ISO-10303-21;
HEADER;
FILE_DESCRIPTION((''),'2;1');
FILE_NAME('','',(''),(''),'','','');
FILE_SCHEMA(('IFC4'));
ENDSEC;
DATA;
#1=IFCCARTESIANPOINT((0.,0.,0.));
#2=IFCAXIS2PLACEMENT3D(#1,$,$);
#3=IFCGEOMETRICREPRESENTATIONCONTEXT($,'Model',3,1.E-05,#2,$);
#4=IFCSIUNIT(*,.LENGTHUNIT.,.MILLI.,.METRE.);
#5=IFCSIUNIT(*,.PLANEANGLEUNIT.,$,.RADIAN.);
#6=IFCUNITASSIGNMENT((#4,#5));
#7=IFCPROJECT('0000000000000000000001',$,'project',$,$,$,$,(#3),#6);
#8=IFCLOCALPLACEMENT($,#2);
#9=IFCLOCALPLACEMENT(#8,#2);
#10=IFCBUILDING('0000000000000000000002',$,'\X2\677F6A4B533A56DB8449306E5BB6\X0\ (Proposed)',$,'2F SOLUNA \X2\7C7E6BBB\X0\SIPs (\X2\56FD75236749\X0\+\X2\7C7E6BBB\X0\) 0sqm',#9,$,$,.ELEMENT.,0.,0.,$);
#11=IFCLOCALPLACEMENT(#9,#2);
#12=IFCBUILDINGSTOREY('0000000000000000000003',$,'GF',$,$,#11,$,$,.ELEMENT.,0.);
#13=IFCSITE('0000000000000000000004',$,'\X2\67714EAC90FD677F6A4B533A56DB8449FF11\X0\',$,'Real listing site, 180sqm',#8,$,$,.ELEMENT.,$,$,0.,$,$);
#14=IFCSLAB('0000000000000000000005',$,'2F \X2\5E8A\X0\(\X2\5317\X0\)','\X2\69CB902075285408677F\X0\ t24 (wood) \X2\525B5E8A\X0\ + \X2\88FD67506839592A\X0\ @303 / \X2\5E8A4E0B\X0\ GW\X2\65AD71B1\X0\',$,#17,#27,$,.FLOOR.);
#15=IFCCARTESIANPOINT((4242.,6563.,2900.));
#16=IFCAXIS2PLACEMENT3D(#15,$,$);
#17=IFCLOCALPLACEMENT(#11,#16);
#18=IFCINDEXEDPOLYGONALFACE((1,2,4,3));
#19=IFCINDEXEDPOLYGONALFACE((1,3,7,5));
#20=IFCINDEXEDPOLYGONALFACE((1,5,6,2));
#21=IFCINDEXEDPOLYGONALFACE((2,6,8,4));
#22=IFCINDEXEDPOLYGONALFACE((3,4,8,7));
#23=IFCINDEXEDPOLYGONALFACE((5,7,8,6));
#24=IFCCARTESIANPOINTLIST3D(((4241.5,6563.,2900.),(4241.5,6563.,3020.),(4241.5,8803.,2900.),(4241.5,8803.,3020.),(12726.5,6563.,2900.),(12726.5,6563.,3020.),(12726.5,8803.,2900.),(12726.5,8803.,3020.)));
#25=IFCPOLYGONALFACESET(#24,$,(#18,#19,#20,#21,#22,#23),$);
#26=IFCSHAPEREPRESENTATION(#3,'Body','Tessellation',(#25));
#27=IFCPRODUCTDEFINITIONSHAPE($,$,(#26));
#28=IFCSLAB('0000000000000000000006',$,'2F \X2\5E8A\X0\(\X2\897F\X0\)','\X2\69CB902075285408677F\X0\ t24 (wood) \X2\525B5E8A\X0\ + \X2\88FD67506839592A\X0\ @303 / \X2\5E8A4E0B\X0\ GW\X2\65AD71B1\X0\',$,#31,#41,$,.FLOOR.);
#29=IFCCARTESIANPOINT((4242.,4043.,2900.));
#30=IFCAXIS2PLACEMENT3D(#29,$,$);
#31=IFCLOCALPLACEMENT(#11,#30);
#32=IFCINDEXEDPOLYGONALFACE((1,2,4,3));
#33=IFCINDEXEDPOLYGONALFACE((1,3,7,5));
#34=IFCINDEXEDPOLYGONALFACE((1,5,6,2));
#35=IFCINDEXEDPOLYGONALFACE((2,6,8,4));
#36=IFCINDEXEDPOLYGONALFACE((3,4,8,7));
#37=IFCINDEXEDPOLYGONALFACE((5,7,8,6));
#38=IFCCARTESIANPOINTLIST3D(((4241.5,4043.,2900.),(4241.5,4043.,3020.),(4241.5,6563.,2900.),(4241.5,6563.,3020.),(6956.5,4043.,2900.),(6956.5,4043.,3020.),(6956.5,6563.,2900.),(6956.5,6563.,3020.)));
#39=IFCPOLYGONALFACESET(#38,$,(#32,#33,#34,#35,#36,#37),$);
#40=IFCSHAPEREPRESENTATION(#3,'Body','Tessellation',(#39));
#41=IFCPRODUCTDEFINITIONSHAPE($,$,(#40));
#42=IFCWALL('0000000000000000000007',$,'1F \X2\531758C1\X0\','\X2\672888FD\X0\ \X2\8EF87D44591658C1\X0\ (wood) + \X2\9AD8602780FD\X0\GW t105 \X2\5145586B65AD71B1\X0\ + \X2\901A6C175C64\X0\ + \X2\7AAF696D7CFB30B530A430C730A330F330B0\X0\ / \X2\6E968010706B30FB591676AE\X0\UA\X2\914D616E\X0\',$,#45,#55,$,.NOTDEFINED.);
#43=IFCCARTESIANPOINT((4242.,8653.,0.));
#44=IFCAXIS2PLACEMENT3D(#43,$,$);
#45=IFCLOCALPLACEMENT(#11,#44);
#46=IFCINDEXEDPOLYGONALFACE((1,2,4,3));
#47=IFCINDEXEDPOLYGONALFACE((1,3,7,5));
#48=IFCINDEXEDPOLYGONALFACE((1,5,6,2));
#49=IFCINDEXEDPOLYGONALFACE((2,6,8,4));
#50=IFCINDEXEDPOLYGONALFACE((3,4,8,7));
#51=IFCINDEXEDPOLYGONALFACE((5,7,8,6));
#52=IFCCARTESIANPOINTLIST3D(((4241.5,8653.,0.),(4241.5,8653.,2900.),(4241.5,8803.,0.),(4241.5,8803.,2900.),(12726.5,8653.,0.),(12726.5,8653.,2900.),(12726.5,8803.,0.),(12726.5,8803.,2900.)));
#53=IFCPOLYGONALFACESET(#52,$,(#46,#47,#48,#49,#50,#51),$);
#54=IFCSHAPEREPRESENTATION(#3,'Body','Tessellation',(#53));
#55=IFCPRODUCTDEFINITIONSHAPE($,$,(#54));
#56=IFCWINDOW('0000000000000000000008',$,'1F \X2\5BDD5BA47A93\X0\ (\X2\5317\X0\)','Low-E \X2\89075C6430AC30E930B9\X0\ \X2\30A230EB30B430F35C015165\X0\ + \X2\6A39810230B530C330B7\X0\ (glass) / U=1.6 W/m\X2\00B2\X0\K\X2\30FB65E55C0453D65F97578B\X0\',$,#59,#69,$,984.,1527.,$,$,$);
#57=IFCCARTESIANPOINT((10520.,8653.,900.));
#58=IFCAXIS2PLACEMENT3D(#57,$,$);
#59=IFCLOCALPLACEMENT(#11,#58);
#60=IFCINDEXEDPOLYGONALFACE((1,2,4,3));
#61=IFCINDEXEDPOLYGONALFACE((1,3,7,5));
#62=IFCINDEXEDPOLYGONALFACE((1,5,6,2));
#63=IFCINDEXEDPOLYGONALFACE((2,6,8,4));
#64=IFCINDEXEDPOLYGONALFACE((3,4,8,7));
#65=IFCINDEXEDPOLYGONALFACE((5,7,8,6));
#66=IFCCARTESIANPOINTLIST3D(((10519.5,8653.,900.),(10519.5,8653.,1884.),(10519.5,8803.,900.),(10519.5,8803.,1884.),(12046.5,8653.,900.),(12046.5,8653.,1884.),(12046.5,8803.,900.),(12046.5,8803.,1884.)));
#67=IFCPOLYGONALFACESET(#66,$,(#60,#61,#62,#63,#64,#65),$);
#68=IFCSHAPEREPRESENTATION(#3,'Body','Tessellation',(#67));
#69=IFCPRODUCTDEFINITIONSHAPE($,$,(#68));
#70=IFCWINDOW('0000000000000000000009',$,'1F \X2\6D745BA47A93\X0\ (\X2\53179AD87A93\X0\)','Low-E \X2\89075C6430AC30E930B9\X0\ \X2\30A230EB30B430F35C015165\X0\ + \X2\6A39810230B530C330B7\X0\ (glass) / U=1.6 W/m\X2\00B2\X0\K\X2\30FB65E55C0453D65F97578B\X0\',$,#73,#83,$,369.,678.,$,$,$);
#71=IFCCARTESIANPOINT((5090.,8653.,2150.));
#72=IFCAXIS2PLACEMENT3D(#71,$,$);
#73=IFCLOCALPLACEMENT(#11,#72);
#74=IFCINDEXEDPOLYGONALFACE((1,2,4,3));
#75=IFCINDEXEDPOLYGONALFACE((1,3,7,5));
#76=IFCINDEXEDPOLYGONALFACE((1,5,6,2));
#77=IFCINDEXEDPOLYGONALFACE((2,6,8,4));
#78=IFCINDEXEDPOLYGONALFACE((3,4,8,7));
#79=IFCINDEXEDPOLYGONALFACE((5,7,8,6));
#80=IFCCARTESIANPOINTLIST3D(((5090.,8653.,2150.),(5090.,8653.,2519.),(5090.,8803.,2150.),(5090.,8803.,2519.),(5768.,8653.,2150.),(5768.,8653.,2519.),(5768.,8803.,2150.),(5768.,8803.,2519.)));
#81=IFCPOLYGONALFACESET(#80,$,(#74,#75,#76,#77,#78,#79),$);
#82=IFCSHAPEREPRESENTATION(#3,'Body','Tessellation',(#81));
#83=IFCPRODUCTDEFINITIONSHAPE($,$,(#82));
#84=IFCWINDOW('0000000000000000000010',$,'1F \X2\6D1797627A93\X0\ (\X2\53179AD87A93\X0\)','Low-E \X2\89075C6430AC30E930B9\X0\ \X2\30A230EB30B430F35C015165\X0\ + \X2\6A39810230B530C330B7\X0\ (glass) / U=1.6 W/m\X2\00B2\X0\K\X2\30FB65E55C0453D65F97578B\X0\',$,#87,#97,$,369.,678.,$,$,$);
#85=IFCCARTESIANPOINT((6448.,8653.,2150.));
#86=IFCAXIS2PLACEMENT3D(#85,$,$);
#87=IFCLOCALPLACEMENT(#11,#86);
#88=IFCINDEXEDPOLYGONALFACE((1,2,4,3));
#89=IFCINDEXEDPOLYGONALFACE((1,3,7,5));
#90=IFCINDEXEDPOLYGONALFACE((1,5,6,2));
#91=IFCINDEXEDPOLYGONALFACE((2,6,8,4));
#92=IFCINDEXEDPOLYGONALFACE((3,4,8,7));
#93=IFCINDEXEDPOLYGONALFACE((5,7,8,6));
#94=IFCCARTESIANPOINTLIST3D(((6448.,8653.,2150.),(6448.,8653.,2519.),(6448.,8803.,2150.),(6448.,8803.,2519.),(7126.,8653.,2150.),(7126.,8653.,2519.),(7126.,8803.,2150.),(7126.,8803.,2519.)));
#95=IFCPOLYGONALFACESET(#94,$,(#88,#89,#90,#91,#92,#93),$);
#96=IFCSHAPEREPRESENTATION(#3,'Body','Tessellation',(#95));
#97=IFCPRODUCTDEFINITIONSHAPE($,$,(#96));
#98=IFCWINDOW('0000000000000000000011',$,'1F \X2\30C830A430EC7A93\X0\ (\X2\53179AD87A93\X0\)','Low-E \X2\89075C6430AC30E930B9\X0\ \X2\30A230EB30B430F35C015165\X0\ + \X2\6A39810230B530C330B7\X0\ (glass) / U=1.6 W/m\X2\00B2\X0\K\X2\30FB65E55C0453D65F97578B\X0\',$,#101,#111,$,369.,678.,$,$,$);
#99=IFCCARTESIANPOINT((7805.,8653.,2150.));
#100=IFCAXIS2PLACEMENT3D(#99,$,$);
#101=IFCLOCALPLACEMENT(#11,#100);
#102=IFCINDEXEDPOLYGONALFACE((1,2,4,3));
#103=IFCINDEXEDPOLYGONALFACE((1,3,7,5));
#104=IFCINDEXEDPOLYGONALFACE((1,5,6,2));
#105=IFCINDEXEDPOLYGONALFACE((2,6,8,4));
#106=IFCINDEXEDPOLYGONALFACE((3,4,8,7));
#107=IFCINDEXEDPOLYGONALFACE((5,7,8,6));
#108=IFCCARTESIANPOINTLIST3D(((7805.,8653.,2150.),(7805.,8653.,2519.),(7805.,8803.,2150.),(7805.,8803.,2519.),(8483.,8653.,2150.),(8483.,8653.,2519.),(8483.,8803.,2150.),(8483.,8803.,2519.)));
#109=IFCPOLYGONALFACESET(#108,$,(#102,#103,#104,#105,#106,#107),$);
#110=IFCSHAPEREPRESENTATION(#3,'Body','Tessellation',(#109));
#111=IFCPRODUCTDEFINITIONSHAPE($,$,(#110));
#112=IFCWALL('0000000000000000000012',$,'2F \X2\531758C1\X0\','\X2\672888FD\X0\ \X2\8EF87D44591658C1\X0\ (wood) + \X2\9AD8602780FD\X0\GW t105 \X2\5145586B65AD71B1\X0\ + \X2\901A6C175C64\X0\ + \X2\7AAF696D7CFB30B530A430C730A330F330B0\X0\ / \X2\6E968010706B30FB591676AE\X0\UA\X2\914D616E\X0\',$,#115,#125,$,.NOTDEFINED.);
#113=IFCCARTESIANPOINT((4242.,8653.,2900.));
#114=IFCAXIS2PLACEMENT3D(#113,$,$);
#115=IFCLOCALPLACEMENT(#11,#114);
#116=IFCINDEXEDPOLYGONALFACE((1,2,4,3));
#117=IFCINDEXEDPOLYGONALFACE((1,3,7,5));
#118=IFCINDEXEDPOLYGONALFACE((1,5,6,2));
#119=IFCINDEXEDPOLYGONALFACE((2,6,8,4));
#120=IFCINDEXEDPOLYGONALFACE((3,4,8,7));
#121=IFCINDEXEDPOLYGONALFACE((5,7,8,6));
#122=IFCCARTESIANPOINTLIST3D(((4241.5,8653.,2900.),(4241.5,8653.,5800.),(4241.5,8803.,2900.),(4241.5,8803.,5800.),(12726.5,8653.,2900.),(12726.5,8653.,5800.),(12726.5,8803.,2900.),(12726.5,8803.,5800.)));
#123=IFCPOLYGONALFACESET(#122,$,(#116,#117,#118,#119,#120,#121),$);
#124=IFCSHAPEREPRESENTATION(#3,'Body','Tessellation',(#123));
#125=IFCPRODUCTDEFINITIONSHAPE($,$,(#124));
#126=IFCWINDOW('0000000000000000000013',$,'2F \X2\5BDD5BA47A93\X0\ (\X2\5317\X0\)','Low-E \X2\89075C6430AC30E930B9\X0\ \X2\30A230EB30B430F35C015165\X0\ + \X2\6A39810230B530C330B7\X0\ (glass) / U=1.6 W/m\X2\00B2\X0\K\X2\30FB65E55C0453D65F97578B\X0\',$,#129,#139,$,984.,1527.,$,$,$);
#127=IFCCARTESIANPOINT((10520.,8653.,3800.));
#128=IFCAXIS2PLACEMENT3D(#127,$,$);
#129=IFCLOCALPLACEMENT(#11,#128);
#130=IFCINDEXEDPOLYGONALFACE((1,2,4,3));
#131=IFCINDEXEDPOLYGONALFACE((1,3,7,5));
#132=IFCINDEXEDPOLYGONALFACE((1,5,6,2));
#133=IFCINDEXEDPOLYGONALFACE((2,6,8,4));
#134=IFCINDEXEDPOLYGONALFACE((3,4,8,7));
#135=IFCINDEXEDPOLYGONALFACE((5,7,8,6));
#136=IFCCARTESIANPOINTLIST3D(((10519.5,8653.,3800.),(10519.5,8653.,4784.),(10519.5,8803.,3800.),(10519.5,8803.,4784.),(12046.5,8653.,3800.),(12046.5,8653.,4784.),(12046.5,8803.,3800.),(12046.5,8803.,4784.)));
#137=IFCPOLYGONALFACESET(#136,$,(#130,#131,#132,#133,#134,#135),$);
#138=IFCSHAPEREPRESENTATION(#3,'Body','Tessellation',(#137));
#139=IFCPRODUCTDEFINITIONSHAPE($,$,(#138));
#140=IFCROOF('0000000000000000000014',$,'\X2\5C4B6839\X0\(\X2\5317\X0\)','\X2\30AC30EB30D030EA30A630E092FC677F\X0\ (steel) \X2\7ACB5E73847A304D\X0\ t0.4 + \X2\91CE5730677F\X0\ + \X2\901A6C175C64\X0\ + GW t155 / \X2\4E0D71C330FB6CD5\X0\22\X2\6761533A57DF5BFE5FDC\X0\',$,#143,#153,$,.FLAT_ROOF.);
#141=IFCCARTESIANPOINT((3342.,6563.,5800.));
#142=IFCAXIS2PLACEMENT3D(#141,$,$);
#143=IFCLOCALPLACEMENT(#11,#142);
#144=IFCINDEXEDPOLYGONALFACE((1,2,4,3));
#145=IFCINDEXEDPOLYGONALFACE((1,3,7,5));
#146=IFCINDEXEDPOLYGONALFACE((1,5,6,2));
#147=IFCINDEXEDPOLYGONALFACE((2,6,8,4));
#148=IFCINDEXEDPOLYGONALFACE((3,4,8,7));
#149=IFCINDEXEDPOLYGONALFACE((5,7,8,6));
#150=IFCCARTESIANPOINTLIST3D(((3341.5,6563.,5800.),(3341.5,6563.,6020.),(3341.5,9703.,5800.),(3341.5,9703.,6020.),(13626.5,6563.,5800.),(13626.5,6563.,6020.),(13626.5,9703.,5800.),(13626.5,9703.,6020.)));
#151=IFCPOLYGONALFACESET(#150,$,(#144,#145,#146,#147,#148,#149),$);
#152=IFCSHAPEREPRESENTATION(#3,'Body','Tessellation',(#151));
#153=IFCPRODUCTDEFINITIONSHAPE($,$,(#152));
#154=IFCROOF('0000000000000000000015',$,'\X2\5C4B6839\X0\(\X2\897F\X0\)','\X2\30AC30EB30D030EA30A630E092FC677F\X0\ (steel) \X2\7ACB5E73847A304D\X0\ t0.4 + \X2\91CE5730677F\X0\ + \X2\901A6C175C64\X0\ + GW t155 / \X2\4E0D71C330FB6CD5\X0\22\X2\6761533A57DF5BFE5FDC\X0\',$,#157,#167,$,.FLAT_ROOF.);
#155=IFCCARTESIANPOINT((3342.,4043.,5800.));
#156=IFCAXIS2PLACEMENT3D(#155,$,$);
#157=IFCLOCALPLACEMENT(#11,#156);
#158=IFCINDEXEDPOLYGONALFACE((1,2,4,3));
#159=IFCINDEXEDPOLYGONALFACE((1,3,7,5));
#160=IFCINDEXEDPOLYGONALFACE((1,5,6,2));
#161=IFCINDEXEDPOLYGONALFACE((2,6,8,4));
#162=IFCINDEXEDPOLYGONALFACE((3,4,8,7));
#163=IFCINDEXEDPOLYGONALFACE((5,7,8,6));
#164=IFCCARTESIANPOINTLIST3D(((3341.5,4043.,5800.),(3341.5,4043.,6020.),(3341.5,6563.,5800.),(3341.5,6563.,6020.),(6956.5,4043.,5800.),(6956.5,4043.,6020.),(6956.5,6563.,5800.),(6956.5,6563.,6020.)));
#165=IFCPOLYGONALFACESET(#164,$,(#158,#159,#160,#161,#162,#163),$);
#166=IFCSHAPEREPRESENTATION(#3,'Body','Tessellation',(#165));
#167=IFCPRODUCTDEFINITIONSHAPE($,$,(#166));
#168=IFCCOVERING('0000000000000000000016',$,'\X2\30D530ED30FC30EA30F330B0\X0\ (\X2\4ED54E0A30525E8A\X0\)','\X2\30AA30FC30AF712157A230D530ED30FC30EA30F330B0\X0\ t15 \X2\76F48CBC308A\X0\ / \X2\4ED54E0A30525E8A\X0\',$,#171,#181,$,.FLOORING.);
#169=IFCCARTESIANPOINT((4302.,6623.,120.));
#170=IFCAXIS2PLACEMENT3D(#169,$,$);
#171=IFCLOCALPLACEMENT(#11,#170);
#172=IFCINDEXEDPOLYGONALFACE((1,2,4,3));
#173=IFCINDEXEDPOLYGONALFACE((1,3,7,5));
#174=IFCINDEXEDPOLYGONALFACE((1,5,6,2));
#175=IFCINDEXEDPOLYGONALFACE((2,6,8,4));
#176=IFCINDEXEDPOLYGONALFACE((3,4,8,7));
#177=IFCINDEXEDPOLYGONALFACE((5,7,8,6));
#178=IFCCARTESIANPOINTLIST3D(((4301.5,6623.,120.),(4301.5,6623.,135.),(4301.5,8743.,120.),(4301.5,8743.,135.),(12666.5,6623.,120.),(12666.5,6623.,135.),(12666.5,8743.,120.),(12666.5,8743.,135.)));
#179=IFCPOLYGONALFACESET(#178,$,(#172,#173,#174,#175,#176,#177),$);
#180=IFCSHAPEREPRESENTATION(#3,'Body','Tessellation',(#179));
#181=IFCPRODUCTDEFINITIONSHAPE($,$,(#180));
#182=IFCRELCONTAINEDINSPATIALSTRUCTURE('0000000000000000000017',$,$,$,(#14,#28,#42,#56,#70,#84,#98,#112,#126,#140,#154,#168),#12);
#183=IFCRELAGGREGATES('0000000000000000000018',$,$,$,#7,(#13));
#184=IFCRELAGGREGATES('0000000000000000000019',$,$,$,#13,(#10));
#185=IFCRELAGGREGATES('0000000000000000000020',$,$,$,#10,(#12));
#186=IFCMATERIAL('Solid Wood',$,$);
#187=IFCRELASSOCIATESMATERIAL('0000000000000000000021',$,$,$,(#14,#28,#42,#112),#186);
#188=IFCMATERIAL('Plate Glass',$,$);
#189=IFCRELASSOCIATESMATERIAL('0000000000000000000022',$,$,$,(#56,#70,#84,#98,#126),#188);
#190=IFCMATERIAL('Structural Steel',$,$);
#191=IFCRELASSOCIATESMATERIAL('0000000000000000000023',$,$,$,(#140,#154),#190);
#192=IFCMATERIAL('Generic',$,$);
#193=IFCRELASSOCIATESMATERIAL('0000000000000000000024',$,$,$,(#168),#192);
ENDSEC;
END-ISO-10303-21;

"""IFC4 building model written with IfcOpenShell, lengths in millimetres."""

from ifc_helpers import new_model, si_unit, frame, frame_2d, origin, place, context, project, spatial, rectangle, extrude, material, element, fill, save


model = new_model("IFC4")

# Units and contexts
model_context = context("Model", 3, precision=1e-05, world=origin())
ifc_project = project(units=[si_unit("LENGTHUNIT", "METRE", prefix="MILLI"), si_unit("PLANEANGLEUNIT", "RADIAN")], contexts=[model_context])

# Site, building, storey
site_placement = place(None, origin())
site = spatial("IfcSite", under=ifc_project, at=site_placement, Name="東京都板橋区四葉１", ObjectType="Real listing site, 180sqm", CompositionType="ELEMENT", RefElevation=0.0)
building_placement = place(site_placement, origin())
building = spatial("IfcBuilding", under=site, at=building_placement, Name="板橋区四葉の家 (Proposed)", ObjectType="2F SOLUNA 籾殻SIPs (国産杉+籾殻) 0sqm", CompositionType="ELEMENT", ElevationOfRefHeight=0.0, ElevationOfTerrain=0.0)
storey_placement = place(building_placement, origin())
storey = spatial("IfcBuildingStorey", under=building, at=storey_placement, Name="GF", CompositionType="ELEMENT", Elevation=0.0)

# Slabs
ifc_material_1 = material(Name="Solid Wood")
slab_1_placement = place(storey_placement, frame((4242.0, 6563.0, 2900.0)))
element("IfcSlab", 1, at=slab_1_placement, inside=storey, material=ifc_material_1, Name="2F 床(北)", Description="構造用合板 t24 (wood) 剛床 + 製材根太 @303 / 床下 GW断熱", PredefinedType="FLOOR", context=model_context, shape_type="SweptSolid", body=[
    extrude(rectangle(XDim=8485.0, YDim=2240.0, at=frame_2d((4242.0, 1120.0))), frame((4242.0, 6563.0, 2900.0)), (0.0, 0.0, 1.0), 120.0),
])
slab_2_placement = place(storey_placement, frame((4242.0, 4043.0, 2900.0)))
element("IfcSlab", 2, at=slab_2_placement, inside=storey, material=ifc_material_1, Name="2F 床(西)", Description="構造用合板 t24 (wood) 剛床 + 製材根太 @303 / 床下 GW断熱", PredefinedType="FLOOR", context=model_context, shape_type="SweptSolid", body=[
    extrude(rectangle(XDim=2715.0, YDim=2520.0, at=frame_2d((1357.0, 1260.0))), frame((4242.0, 4043.0, 2900.0)), (0.0, 0.0, 1.0), 120.0),
])

# Wall, openings, windows
wall_1_placement = place(storey_placement, frame((4242.0, 8653.0, 0.0)))
wall_1 = element("IfcWall", 3, at=wall_1_placement, inside=storey, material=ifc_material_1, Name="1F 北壁", Description="木製 軸組外壁 (wood) + 高性能GW t105 充填断熱 + 通気層 + 窯業系サイディング / 準耐火・外皮UA配慮", PredefinedType="NOTDEFINED", context=model_context, shape_type="SweptSolid", body=[
    extrude(rectangle(XDim=8485.0, YDim=150.0, at=frame_2d((4242.0, 75.0))), frame((4242.0, 8653.0, 0.0)), (0.0, 0.0, 1.0), 2900.0),
])
opening_1_placement = place(storey_placement, frame((10520.0, 8653.0, 900.0)))
opening_1 = element("IfcOpeningElement", 4, at=opening_1_placement, cuts=wall_1, PredefinedType="NOTDEFINED", context=model_context, shape_type="SweptSolid", body=[
    extrude(rectangle(XDim=1527.0, YDim=150.0, at=frame_2d((763.0, 75.0))), frame((10520.0, 8653.0, 900.0)), (0.0, 0.0, 1.0), 984.0),
])
opening_2_placement = place(storey_placement, frame((5090.0, 8653.0, 2150.0)))
opening_2 = element("IfcOpeningElement", 5, at=opening_2_placement, cuts=wall_1, PredefinedType="NOTDEFINED", context=model_context, shape_type="SweptSolid", body=[
    extrude(rectangle(XDim=678.0, YDim=150.0, at=frame_2d((339.0, 75.0))), frame((5090.0, 8653.0, 2150.0)), (0.0, 0.0, 1.0), 369.0),
])
opening_3_placement = place(storey_placement, frame((6448.0, 8653.0, 2150.0)))
opening_3 = element("IfcOpeningElement", 6, at=opening_3_placement, cuts=wall_1, PredefinedType="NOTDEFINED", context=model_context, shape_type="SweptSolid", body=[
    extrude(rectangle(XDim=678.0, YDim=150.0, at=frame_2d((339.0, 75.0))), frame((6448.0, 8653.0, 2150.0)), (0.0, 0.0, 1.0), 369.0),
])
opening_4_placement = place(storey_placement, frame((7805.0, 8653.0, 2150.0)))
opening_4 = element("IfcOpeningElement", 7, at=opening_4_placement, cuts=wall_1, PredefinedType="NOTDEFINED", context=model_context, shape_type="SweptSolid", body=[
    extrude(rectangle(XDim=678.0, YDim=150.0, at=frame_2d((339.0, 75.0))), frame((7805.0, 8653.0, 2150.0)), (0.0, 0.0, 1.0), 369.0),
])
ifc_material_2 = material(Name="Plate Glass")
window_1_placement = place(storey_placement, frame((10520.0, 8653.0, 900.0)))
window_1 = element("IfcWindow", 8, at=window_1_placement, inside=storey, material=ifc_material_2, Name="1F 寝室窓 (北)", Description="Low-E 複層ガラス アルゴン封入 + 樹脂サッシ (glass) / U=1.6 W/m²K・日射取得型", OverallHeight=984.0, OverallWidth=1527.0, context=model_context, shape_type="SweptSolid", body=[
    extrude(rectangle(XDim=1527.0, YDim=150.0, at=frame_2d((763.0, 75.0))), frame((10520.0, 8653.0, 900.0)), (0.0, 0.0, 1.0), 984.0),
])
fill(opening_1, window_1)
window_2_placement = place(storey_placement, frame((5090.0, 8653.0, 2150.0)))
window_2 = element("IfcWindow", 9, at=window_2_placement, inside=storey, material=ifc_material_2, Name="1F 浴室窓 (北高窓)", Description="Low-E 複層ガラス アルゴン封入 + 樹脂サッシ (glass) / U=1.6 W/m²K・日射取得型", OverallHeight=369.0, OverallWidth=678.0, context=model_context, shape_type="SweptSolid", body=[
    extrude(rectangle(XDim=678.0, YDim=150.0, at=frame_2d((339.0, 75.0))), frame((5090.0, 8653.0, 2150.0)), (0.0, 0.0, 1.0), 369.0),
])
fill(opening_2, window_2)
window_3_placement = place(storey_placement, frame((6448.0, 8653.0, 2150.0)))
window_3 = element("IfcWindow", 10, at=window_3_placement, inside=storey, material=ifc_material_2, Name="1F 洗面窓 (北高窓)", Description="Low-E 複層ガラス アルゴン封入 + 樹脂サッシ (glass) / U=1.6 W/m²K・日射取得型", OverallHeight=369.0, OverallWidth=678.0, context=model_context, shape_type="SweptSolid", body=[
    extrude(rectangle(XDim=678.0, YDim=150.0, at=frame_2d((339.0, 75.0))), frame((6448.0, 8653.0, 2150.0)), (0.0, 0.0, 1.0), 369.0),
])
fill(opening_3, window_3)
window_4_placement = place(storey_placement, frame((7805.0, 8653.0, 2150.0)))
window_4 = element("IfcWindow", 11, at=window_4_placement, inside=storey, material=ifc_material_2, Name="1F トイレ窓 (北高窓)", Description="Low-E 複層ガラス アルゴン封入 + 樹脂サッシ (glass) / U=1.6 W/m²K・日射取得型", OverallHeight=369.0, OverallWidth=678.0, context=model_context, shape_type="SweptSolid", body=[
    extrude(rectangle(XDim=678.0, YDim=150.0, at=frame_2d((339.0, 75.0))), frame((7805.0, 8653.0, 2150.0)), (0.0, 0.0, 1.0), 369.0),
])
fill(opening_4, window_4)

# Wall, opening, window
wall_2_placement = place(storey_placement, frame((4242.0, 8653.0, 2900.0)))
wall_2 = element("IfcWall", 12, at=wall_2_placement, inside=storey, material=ifc_material_1, Name="2F 北壁", Description="木製 軸組外壁 (wood) + 高性能GW t105 充填断熱 + 通気層 + 窯業系サイディング / 準耐火・外皮UA配慮", PredefinedType="NOTDEFINED", context=model_context, shape_type="SweptSolid", body=[
    extrude(rectangle(XDim=8485.0, YDim=150.0, at=frame_2d((4242.0, 75.0))), frame((4242.0, 8653.0, 2900.0)), (0.0, 0.0, 1.0), 2900.0),
])
opening_5_placement = place(storey_placement, frame((10520.0, 8653.0, 3800.0)))
opening_5 = element("IfcOpeningElement", 13, at=opening_5_placement, cuts=wall_2, PredefinedType="NOTDEFINED", context=model_context, shape_type="SweptSolid", body=[
    extrude(rectangle(XDim=1527.0, YDim=150.0, at=frame_2d((763.0, 75.0))), frame((10520.0, 8653.0, 3800.0)), (0.0, 0.0, 1.0), 984.0),
])
window_5_placement = place(storey_placement, frame((10520.0, 8653.0, 3800.0)))
window_5 = element("IfcWindow", 14, at=window_5_placement, inside=storey, material=ifc_material_2, Name="2F 寝室窓 (北)", Description="Low-E 複層ガラス アルゴン封入 + 樹脂サッシ (glass) / U=1.6 W/m²K・日射取得型", OverallHeight=984.0, OverallWidth=1527.0, context=model_context, shape_type="SweptSolid", body=[
    extrude(rectangle(XDim=1527.0, YDim=150.0, at=frame_2d((763.0, 75.0))), frame((10520.0, 8653.0, 3800.0)), (0.0, 0.0, 1.0), 984.0),
])
fill(opening_5, window_5)

# Roofs
ifc_material_3 = material(Name="Structural Steel")
for number, where, name in (
    (15, (3342.0, 6563.0, 5800.0), "屋根(北)"),
):
    element("IfcRoof", number, at=place(storey_placement, frame(where)), inside=storey, material=ifc_material_3, Name=name, Description="ガルバリウム鋼板 (steel) 立平葺き t0.4 + 野地板 + 通気層 + GW t155 / 不燃・法22条区域対応", PredefinedType="FLAT_ROOF", context=model_context, shape_type="SweptSolid", body=[
        extrude(rectangle(XDim=10285.0, YDim=3140.0, at=frame_2d((5142.0, 1570.0))), frame((3342.0, 6563.0, 5800.0)), (0.0, 0.0, 1.0), 220.0),
    ])
roof_placement = place(storey_placement, frame((3342.0, 4043.0, 5800.0)))
element("IfcRoof", 16, at=roof_placement, inside=storey, material=ifc_material_3, Name="屋根(西)", Description="ガルバリウム鋼板 (steel) 立平葺き t0.4 + 野地板 + 通気層 + GW t155 / 不燃・法22条区域対応", PredefinedType="FLAT_ROOF", context=model_context, shape_type="SweptSolid", body=[
    extrude(rectangle(XDim=3615.0, YDim=2520.0, at=frame_2d((1807.0, 1260.0))), frame((3342.0, 4043.0, 5800.0)), (0.0, 0.0, 1.0), 220.0),
])

# Covering
ifc_material_4 = material(Name="Generic")
covering_1_placement = place(storey_placement, frame((4302.0, 6623.0, 120.0)))
element("IfcCovering", 17, at=covering_1_placement, inside=storey, material=ifc_material_4, Name="フローリング (仕上げ床)", Description="オーク無垢フローリング t15 直貼り / 仕上げ床", PredefinedType="FLOORING", context=model_context, shape_type="SweptSolid", body=[
    extrude(rectangle(XDim=8365.0, YDim=2120.0, at=frame_2d((4182.0, 1060.0))), frame((4302.0, 6623.0, 120.0)), (0.0, 0.0, 1.0), 15.0),
])

save(model, "model.ifc")
